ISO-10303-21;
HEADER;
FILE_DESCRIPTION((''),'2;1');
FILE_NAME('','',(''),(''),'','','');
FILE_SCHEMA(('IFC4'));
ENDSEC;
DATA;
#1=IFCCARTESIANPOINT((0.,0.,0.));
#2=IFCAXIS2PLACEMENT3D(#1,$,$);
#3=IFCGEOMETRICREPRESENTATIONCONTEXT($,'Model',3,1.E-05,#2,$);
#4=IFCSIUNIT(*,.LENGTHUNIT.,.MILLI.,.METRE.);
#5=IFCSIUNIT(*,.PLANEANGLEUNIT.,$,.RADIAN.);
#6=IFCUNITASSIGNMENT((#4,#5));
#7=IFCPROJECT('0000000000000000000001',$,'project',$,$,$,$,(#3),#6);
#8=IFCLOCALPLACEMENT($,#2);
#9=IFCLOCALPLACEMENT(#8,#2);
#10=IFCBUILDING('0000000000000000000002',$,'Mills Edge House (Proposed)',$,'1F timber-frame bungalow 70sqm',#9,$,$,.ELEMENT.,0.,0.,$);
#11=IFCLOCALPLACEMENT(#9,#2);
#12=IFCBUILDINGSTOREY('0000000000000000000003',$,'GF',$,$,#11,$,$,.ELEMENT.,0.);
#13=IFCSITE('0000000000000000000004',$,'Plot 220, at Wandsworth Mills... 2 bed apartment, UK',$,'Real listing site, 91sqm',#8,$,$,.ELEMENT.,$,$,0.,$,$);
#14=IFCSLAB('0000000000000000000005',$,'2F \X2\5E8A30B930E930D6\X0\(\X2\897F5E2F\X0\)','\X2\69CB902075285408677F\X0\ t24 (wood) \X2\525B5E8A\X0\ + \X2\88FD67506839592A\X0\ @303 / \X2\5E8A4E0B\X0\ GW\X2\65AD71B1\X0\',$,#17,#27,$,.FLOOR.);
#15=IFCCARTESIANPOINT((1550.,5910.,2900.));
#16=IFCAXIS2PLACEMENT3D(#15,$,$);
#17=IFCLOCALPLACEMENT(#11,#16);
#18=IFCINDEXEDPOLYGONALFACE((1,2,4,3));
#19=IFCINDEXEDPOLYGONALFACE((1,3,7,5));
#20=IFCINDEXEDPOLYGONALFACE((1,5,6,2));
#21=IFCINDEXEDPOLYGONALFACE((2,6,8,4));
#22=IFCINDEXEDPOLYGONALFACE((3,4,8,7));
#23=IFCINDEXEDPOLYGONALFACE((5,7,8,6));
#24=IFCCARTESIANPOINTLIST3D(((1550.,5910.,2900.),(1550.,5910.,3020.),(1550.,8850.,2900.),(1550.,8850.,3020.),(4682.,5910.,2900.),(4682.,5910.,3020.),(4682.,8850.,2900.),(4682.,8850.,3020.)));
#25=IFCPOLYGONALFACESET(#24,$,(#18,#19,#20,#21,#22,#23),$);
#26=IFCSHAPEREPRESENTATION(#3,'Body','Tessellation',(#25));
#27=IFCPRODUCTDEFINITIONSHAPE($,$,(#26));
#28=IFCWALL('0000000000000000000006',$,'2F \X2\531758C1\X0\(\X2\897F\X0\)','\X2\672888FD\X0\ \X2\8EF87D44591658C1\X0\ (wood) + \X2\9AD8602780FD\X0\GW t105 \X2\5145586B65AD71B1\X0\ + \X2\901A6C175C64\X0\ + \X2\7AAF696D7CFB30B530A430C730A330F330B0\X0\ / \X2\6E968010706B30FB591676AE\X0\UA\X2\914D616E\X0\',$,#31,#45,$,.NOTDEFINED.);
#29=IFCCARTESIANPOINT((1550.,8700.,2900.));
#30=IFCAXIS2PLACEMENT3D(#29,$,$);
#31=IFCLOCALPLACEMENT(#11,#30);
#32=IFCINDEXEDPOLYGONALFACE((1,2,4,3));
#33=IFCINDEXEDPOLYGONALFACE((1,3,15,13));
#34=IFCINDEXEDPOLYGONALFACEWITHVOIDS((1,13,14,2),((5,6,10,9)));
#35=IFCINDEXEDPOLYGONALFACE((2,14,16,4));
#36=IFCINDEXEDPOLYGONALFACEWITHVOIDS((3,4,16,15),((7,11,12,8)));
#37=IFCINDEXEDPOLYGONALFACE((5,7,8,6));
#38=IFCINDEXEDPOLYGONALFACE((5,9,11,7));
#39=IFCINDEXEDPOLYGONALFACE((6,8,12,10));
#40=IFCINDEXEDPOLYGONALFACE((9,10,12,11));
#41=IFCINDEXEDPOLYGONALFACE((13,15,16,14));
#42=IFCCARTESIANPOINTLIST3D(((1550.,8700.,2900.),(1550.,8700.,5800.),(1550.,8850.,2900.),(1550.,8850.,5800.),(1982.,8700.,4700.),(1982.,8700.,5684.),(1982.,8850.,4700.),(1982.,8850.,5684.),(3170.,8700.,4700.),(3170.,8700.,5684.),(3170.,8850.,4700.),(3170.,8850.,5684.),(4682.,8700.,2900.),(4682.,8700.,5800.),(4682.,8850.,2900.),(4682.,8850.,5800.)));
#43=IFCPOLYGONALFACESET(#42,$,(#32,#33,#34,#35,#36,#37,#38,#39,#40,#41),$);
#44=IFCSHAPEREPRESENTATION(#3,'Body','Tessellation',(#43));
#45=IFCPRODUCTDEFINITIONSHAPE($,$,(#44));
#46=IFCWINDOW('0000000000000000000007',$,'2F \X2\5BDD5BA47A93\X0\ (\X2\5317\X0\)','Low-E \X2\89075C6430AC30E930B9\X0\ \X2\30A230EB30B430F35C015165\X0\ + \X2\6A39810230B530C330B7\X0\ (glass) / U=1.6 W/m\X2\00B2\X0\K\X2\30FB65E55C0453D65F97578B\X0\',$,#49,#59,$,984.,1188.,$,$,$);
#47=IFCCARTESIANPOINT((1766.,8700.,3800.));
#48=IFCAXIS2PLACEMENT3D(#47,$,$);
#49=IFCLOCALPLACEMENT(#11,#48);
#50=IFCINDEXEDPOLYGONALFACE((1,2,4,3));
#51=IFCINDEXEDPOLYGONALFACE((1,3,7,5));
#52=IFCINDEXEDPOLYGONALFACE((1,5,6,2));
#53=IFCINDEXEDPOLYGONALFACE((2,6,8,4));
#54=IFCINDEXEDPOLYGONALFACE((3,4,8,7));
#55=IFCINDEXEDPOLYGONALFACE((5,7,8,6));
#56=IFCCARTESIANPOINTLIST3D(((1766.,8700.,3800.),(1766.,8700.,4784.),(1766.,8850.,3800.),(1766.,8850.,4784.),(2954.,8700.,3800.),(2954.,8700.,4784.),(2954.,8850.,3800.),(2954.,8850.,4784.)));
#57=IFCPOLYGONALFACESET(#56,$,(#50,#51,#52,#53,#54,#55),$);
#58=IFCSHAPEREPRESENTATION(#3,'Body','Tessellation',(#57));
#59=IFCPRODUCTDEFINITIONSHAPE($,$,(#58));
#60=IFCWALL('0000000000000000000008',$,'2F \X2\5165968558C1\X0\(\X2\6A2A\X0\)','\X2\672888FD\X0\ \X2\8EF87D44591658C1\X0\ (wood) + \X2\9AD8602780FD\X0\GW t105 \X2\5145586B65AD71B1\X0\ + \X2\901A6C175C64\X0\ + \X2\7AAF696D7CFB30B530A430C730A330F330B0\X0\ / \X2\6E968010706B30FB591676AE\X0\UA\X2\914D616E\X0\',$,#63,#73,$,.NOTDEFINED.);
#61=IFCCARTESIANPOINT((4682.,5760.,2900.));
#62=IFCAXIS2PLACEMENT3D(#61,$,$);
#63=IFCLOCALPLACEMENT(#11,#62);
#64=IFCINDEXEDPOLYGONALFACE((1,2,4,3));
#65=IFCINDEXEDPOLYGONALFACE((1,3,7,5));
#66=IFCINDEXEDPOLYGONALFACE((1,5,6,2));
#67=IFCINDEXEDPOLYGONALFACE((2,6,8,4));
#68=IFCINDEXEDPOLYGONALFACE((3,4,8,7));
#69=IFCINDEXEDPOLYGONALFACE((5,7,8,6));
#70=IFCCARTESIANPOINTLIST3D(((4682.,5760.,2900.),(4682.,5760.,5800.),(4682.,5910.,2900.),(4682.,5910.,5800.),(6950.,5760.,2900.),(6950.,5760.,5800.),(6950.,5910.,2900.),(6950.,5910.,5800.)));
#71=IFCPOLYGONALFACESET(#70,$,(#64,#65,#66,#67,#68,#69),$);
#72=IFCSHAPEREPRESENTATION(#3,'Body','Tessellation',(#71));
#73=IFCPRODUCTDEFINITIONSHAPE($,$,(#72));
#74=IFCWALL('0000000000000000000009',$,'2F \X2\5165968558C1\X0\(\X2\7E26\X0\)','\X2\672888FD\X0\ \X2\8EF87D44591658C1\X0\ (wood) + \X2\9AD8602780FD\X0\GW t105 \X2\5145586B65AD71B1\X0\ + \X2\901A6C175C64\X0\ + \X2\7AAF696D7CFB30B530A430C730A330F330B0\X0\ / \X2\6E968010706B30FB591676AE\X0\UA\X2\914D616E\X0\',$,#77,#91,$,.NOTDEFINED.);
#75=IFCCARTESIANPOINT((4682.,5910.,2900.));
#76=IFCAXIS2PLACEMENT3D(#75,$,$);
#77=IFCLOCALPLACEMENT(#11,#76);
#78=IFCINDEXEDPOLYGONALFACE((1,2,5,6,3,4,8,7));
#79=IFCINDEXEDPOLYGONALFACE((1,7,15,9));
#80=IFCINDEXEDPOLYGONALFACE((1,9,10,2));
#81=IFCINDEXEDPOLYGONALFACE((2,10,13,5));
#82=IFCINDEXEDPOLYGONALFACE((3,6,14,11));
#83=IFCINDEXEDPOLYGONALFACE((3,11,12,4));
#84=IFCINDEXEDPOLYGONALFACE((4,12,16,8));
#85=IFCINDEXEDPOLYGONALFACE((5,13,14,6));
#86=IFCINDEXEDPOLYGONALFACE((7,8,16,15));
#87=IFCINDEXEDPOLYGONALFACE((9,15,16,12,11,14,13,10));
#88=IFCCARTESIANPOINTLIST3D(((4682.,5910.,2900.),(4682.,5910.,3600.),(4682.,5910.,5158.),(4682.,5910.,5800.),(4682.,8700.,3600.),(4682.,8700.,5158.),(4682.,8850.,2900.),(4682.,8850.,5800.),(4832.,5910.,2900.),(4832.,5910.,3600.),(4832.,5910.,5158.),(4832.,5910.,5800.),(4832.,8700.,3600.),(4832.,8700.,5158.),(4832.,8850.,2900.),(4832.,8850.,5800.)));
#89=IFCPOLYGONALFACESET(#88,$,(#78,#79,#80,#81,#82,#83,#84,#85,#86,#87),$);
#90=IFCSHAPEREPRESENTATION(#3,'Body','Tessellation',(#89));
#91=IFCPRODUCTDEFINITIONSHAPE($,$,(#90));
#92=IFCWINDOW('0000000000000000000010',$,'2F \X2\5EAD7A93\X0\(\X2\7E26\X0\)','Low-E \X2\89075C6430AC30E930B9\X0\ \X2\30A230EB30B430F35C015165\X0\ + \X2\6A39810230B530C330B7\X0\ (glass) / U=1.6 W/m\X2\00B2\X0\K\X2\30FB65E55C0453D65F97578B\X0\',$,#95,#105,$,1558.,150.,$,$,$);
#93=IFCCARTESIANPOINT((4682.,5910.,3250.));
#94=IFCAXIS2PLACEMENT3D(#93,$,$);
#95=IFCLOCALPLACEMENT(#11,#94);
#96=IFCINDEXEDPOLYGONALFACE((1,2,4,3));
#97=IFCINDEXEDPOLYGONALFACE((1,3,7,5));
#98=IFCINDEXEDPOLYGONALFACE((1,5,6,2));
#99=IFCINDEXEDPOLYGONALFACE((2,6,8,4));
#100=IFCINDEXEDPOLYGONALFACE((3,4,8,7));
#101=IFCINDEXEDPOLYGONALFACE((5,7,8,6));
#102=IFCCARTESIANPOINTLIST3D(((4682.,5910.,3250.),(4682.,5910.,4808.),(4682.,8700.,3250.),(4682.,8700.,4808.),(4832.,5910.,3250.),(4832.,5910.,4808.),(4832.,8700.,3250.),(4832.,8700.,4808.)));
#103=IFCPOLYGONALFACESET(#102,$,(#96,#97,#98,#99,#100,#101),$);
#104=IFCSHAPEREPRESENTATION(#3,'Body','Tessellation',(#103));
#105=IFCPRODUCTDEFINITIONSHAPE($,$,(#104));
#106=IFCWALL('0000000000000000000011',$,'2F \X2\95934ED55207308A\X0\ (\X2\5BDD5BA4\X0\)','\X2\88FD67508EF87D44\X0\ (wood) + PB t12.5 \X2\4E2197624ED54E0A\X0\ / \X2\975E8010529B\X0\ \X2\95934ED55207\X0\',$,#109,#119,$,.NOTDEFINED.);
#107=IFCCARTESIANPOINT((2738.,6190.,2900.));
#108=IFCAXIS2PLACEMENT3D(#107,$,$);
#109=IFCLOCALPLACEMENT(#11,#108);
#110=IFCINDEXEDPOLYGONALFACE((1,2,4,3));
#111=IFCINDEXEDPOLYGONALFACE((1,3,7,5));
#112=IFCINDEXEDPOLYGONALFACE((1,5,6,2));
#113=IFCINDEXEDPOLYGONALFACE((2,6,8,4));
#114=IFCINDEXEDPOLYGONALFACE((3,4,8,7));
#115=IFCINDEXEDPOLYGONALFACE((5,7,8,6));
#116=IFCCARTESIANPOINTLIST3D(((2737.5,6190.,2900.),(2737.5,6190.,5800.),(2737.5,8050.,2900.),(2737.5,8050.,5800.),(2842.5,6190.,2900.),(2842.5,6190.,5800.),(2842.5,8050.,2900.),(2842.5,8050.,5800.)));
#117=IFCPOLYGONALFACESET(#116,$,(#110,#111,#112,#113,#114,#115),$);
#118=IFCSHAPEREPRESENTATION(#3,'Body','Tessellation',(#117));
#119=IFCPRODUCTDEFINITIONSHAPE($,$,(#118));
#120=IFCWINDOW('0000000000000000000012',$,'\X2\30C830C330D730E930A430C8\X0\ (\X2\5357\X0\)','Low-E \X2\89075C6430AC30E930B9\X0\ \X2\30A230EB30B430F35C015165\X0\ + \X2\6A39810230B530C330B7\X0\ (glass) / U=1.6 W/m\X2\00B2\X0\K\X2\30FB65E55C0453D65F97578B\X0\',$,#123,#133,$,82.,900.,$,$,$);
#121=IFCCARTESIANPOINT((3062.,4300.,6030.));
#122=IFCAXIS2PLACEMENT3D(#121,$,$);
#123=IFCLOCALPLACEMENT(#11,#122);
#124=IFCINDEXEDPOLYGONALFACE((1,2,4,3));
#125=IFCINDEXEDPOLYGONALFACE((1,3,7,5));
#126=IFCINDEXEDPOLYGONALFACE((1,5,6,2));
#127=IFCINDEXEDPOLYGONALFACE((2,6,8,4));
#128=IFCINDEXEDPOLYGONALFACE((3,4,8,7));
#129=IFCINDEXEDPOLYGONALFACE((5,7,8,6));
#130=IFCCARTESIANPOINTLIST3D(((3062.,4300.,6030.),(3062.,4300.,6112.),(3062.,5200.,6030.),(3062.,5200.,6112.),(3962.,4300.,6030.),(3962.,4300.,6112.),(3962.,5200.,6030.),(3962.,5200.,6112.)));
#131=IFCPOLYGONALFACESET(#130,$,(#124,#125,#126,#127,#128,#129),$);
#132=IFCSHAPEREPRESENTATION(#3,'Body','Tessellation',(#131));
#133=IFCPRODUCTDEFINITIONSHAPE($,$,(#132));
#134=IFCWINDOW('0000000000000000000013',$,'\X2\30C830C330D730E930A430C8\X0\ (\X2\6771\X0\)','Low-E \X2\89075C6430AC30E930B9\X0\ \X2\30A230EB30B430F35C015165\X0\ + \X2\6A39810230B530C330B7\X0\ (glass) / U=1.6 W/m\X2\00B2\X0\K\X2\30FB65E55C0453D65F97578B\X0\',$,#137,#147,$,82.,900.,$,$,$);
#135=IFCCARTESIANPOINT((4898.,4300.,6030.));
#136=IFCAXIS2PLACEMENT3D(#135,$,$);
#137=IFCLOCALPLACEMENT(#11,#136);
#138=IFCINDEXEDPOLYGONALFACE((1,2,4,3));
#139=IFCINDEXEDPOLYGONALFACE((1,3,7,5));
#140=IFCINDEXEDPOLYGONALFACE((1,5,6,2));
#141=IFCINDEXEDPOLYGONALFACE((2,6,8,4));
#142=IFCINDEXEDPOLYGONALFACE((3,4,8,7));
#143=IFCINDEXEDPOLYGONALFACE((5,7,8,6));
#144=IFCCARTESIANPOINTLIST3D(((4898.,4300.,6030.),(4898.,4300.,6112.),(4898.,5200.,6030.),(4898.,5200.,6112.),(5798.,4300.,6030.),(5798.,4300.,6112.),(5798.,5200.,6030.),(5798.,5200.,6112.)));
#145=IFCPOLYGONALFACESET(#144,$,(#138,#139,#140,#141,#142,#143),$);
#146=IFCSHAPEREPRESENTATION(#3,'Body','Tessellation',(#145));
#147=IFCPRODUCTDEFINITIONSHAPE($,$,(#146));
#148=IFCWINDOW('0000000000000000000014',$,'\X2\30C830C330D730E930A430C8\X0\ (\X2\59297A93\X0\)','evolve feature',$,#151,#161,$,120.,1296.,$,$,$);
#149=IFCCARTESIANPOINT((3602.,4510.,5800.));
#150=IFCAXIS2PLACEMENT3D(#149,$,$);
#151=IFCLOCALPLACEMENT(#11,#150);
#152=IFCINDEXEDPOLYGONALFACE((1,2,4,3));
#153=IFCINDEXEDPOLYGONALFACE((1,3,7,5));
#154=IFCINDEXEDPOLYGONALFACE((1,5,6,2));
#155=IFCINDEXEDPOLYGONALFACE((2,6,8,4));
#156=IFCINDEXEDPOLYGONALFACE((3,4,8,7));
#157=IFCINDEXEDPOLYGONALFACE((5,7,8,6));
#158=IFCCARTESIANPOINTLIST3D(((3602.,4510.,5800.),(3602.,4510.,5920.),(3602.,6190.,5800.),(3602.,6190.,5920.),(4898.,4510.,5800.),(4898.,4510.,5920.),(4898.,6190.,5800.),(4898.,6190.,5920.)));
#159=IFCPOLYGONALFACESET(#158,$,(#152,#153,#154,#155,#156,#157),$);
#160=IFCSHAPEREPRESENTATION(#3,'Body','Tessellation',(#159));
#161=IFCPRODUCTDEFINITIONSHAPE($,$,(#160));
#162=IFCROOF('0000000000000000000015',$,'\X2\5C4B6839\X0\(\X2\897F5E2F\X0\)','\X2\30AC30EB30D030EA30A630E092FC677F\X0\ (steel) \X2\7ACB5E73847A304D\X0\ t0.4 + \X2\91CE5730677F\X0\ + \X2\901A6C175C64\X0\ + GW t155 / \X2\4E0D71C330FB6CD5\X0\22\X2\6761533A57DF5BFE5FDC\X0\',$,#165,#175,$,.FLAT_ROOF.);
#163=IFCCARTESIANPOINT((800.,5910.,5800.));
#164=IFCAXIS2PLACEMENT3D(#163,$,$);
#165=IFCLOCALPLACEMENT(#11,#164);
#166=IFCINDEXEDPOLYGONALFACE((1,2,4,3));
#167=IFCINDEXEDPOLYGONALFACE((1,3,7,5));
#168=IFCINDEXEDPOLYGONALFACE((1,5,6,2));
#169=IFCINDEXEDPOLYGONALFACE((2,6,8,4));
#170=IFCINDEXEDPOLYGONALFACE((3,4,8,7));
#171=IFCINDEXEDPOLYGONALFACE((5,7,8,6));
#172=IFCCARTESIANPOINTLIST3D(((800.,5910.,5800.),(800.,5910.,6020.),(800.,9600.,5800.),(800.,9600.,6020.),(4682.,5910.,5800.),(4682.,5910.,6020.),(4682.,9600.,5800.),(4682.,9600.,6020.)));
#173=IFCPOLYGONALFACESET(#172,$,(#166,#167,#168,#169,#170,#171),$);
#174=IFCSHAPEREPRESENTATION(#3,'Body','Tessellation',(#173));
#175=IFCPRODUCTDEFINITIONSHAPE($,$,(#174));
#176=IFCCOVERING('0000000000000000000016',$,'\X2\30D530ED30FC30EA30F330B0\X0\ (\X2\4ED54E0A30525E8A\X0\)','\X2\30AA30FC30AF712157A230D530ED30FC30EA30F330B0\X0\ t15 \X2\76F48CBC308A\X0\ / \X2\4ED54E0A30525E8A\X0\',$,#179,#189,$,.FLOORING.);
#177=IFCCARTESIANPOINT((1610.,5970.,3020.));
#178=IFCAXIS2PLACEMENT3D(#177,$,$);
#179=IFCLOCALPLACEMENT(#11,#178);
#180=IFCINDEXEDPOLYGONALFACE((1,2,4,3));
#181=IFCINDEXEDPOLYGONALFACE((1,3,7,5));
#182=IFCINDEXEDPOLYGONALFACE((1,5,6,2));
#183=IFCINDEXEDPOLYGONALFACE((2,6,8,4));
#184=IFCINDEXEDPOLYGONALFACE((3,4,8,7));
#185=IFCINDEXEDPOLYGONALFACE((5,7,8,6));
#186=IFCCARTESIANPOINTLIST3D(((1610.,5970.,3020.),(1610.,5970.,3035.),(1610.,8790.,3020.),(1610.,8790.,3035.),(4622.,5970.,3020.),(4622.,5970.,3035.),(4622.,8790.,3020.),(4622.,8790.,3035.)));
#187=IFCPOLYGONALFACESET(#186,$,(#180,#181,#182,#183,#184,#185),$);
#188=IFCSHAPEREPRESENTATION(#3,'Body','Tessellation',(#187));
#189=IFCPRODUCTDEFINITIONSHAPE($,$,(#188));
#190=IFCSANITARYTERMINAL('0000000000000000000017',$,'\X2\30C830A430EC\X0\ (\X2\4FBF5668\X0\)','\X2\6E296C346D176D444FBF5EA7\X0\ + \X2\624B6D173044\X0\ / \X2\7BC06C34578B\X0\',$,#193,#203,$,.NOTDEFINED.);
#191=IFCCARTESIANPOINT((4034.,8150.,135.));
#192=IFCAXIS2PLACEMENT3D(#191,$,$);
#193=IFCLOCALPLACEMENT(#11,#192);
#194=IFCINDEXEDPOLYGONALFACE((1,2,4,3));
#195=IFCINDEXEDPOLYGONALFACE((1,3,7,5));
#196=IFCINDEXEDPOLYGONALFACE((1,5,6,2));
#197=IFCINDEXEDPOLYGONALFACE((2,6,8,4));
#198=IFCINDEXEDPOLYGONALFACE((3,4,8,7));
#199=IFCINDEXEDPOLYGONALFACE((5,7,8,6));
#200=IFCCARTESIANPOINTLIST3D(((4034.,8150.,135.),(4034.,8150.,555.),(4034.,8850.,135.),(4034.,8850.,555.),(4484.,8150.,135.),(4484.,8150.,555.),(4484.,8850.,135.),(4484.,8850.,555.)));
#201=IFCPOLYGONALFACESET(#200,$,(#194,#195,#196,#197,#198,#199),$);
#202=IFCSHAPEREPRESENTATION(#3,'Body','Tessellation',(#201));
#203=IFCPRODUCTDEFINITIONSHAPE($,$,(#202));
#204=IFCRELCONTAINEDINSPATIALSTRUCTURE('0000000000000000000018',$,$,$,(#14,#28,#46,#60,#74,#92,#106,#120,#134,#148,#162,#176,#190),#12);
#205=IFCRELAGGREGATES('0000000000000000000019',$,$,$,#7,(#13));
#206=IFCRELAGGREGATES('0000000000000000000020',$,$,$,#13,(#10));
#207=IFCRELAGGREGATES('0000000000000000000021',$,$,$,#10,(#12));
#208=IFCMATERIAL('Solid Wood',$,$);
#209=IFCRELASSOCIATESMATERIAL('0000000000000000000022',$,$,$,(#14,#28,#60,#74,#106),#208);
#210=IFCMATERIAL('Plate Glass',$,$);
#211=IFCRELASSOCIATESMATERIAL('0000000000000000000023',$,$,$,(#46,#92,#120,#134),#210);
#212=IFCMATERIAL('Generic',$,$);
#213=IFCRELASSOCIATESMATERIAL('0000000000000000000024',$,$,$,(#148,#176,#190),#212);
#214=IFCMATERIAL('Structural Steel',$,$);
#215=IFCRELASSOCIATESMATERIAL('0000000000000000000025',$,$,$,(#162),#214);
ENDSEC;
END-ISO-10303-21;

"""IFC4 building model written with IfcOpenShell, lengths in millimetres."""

from ifc_helpers import new_model, si_unit, frame, frame_2d, origin, place, context, project, spatial, rectangle, extrude, material, element, fill, save


model = new_model("IFC4")

# Units and contexts
model_context = context("Model", 3, precision=1e-05, world=origin())
ifc_project = project(units=[si_unit("LENGTHUNIT", "METRE", prefix="MILLI"), si_unit("PLANEANGLEUNIT", "RADIAN")], contexts=[model_context])

# Site, building, storey
site_placement = place(None, origin())
site = spatial("IfcSite", under=ifc_project, at=site_placement, Name="Plot 220, at Wandsworth Mills... 2 bed apartment, UK", ObjectType="Real listing site, 91sqm", CompositionType="ELEMENT", RefElevation=0.0)
building_placement = place(site_placement, origin())
building = spatial("IfcBuilding", under=site, at=building_placement, Name="Mills Edge House (Proposed)", ObjectType="1F timber-frame bungalow 70sqm", CompositionType="ELEMENT", ElevationOfRefHeight=0.0, ElevationOfTerrain=0.0)
storey_placement = place(building_placement, origin())
storey = spatial("IfcBuildingStorey", under=building, at=storey_placement, Name="GF", CompositionType="ELEMENT", Elevation=0.0)

# Slab
ifc_material_1 = material(Name="Solid Wood")
slab_placement = place(storey_placement, frame((1550.0, 5910.0, 2900.0)))
element("IfcSlab", 1, at=slab_placement, inside=storey, material=ifc_material_1, Name="2F 床スラブ(西帯)", Description="構造用合板 t24 (wood) 剛床 + 製材根太 @303 / 床下 GW断熱", PredefinedType="FLOOR", context=model_context, shape_type="SweptSolid", body=[
    extrude(rectangle(XDim=3132.0, YDim=2940.0, at=frame_2d((1566.0, 1470.0))), frame((1550.0, 5910.0, 2900.0)), (0.0, 0.0, 1.0), 120.0),
])

# Wall, opening, window
wall_1_placement = place(storey_placement, frame((1550.0, 8700.0, 2900.0)))
wall_1 = element("IfcWall", 2, at=wall_1_placement, inside=storey, material=ifc_material_1, Name="2F 北壁(西)", Description="木製 軸組外壁 (wood) + 高性能GW t105 充填断熱 + 通気層 + 窯業系サイディング / 準耐火・外皮UA配慮", PredefinedType="NOTDEFINED", context=model_context, shape_type="SweptSolid", body=[
    extrude(rectangle(XDim=3132.0, YDim=150.0, at=frame_2d((1566.0, 75.0))), frame((1550.0, 8700.0, 2900.0)), (0.0, 0.0, 1.0), 2900.0),
])
opening_1_placement = place(storey_placement, frame((1766.0, 8700.0, 3800.0)))
opening_1 = element("IfcOpeningElement", 3, at=opening_1_placement, cuts=wall_1, PredefinedType="NOTDEFINED", context=model_context, shape_type="SweptSolid", body=[
    extrude(rectangle(XDim=1188.0, YDim=150.0, at=frame_2d((594.0, 75.0))), frame((1766.0, 8700.0, 3800.0)), (0.0, 0.0, 1.0), 984.0),
])
ifc_material_2 = material(Name="Plate Glass")
window_1_placement = place(storey_placement, frame((1766.0, 8700.0, 3800.0)))
window_1 = element("IfcWindow", 4, at=window_1_placement, inside=storey, material=ifc_material_2, Name="2F 寝室窓 (北)", Description="Low-E 複層ガラス アルゴン封入 + 樹脂サッシ (glass) / U=1.6 W/m²K・日射取得型", OverallHeight=984.0, OverallWidth=1188.0, context=model_context, shape_type="SweptSolid", body=[
    extrude(rectangle(XDim=1188.0, YDim=150.0, at=frame_2d((594.0, 75.0))), frame((1766.0, 8700.0, 3800.0)), (0.0, 0.0, 1.0), 984.0),
])
fill(opening_1, window_1)

# Wall
wall_2_placement = place(storey_placement, frame((4682.0, 5760.0, 2900.0)))
element("IfcWall", 5, at=wall_2_placement, inside=storey, material=ifc_material_1, Name="2F 入隅壁(横)", Description="木製 軸組外壁 (wood) + 高性能GW t105 充填断熱 + 通気層 + 窯業系サイディング / 準耐火・外皮UA配慮", PredefinedType="NOTDEFINED", context=model_context, shape_type="SweptSolid", body=[
    extrude(rectangle(XDim=2268.0, YDim=150.0, at=frame_2d((1134.0, 75.0))), frame((4682.0, 5760.0, 2900.0)), (0.0, 0.0, 1.0), 2900.0),
])

# Wall, opening, window
wall_3_placement = place(storey_placement, frame((4682.0, 5910.0, 2900.0)))
wall_3 = element("IfcWall", 6, at=wall_3_placement, inside=storey, material=ifc_material_1, Name="2F 入隅壁(縦)", Description="木製 軸組外壁 (wood) + 高性能GW t105 充填断熱 + 通気層 + 窯業系サイディング / 準耐火・外皮UA配慮", PredefinedType="NOTDEFINED", context=model_context, shape_type="SweptSolid", body=[
    extrude(rectangle(XDim=150.0, YDim=2940.0, at=frame_2d((75.0, 1470.0))), frame((4682.0, 5910.0, 2900.0)), (0.0, 0.0, 1.0), 2900.0),
])
opening_2_placement = place(storey_placement, frame((4682.0, 5910.0, 3250.0)))
opening_2 = element("IfcOpeningElement", 7, at=opening_2_placement, cuts=wall_3, PredefinedType="NOTDEFINED", context=model_context, shape_type="SweptSolid", body=[
    extrude(rectangle(XDim=150.0, YDim=2790.0, at=frame_2d((75.0, 1395.0))), frame((4682.0, 5910.0, 3250.0)), (0.0, 0.0, 1.0), 1558.0),
])
window_2_placement = place(storey_placement, frame((4682.0, 5910.0, 3250.0)))
window_2 = element("IfcWindow", 8, at=window_2_placement, inside=storey, material=ifc_material_2, Name="2F 庭窓(縦)", Description="Low-E 複層ガラス アルゴン封入 + 樹脂サッシ (glass) / U=1.6 W/m²K・日射取得型", OverallHeight=1558.0, OverallWidth=150.0, context=model_context, shape_type="SweptSolid", body=[
    extrude(rectangle(XDim=150.0, YDim=2790.0, at=frame_2d((75.0, 1395.0))), frame((4682.0, 5910.0, 3250.0)), (0.0, 0.0, 1.0), 1558.0),
])
fill(opening_2, window_2)

# Wall
wall_4_placement = place(storey_placement, frame((2738.0, 6190.0, 2900.0)))
element("IfcWall", 9, at=wall_4_placement, inside=storey, material=ifc_material_1, Name="2F 間仕切り (寝室)", Description="製材軸組 (wood) + PB t12.5 両面仕上 / 非耐力 間仕切", PredefinedType="NOTDEFINED", context=model_context, shape_type="SweptSolid", body=[
    extrude(rectangle(XDim=105.0, YDim=1860.0, at=frame_2d((52.0, 930.0))), frame((2738.0, 6190.0, 2900.0)), (0.0, 0.0, 1.0), 2900.0),
])

# Windows
window_3_placement = place(storey_placement, frame((3062.0, 4300.0, 6030.0)))
element("IfcWindow", 10, at=window_3_placement, inside=storey, material=ifc_material_2, Name="トップライト (南)", Description="Low-E 複層ガラス アルゴン封入 + 樹脂サッシ (glass) / U=1.6 W/m²K・日射取得型", OverallHeight=82.0, OverallWidth=900.0, context=model_context, shape_type="SweptSolid", body=[
    extrude(rectangle(XDim=900.0, YDim=900.0, at=frame_2d((450.0, 450.0))), frame((3062.0, 4300.0, 6030.0)), (0.0, 0.0, 1.0), 82.0),
])
window_4_placement = place(storey_placement, frame((4898.0, 4300.0, 6030.0)))
element("IfcWindow", 11, at=window_4_placement, inside=storey, material=ifc_material_2, Name="トップライト (東)", Description="Low-E 複層ガラス アルゴン封入 + 樹脂サッシ (glass) / U=1.6 W/m²K・日射取得型", OverallHeight=82.0, OverallWidth=900.0, context=model_context, shape_type="SweptSolid", body=[
    extrude(rectangle(XDim=900.0, YDim=900.0, at=frame_2d((450.0, 450.0))), frame((4898.0, 4300.0, 6030.0)), (0.0, 0.0, 1.0), 82.0),
])
ifc_material_3 = material(Name="Generic")
window_5_placement = place(storey_placement, frame((3602.0, 4510.0, 5800.0)))
element("IfcWindow", 12, at=window_5_placement, inside=storey, material=ifc_material_3, Name="トップライト (天窓)", Description="evolve feature", OverallHeight=120.0, OverallWidth=1296.0, context=model_context, shape_type="SweptSolid", body=[
    extrude(rectangle(XDim=1296.0, YDim=1680.0, at=frame_2d((648.0, 840.0))), frame((3602.0, 4510.0, 5800.0)), (0.0, 0.0, 1.0), 120.0),
])

# Roof
ifc_material_4 = material(Name="Structural Steel")
for number, where, name in (
    (13, (800.0, 5910.0, 5800.0), "屋根(西帯)"),
):
    element("IfcRoof", number, at=place(storey_placement, frame(where)), inside=storey, material=ifc_material_4, Name=name, Description="ガルバリウム鋼板 (steel) 立平葺き t0.4 + 野地板 + 通気層 + GW t155 / 不燃・法22条区域対応", PredefinedType="FLAT_ROOF", context=model_context, shape_type="SweptSolid", body=[
        extrude(rectangle(XDim=3882.0, YDim=3690.0, at=frame_2d((1941.0, 1845.0))), frame((800.0, 5910.0, 5800.0)), (0.0, 0.0, 1.0), 220.0),
    ])

# Covering
covering_placement = place(storey_placement, frame((1610.0, 5970.0, 3020.0)))
element("IfcCovering", 14, at=covering_placement, inside=storey, material=ifc_material_3, Name="フローリング (仕上げ床)", Description="オーク無垢フローリング t15 直貼り / 仕上げ床", PredefinedType="FLOORING", context=model_context, shape_type="SweptSolid", body=[
    extrude(rectangle(XDim=3012.0, YDim=2820.0, at=frame_2d((1506.0, 1410.0))), frame((1610.0, 5970.0, 3020.0)), (0.0, 0.0, 1.0), 15.0),
])

# Sanitary terminal
sanitary_terminal_placement = place(storey_placement, frame((4034.0, 8150.0, 135.0)))
element("IfcSanitaryTerminal", 15, at=sanitary_terminal_placement, inside=storey, material=ifc_material_3, Name="トイレ (便器)", Description="温水洗浄便座 + 手洗い / 節水型", PredefinedType="NOTDEFINED", context=model_context, shape_type="SweptSolid", body=[
    extrude(rectangle(XDim=450.0, YDim=700.0, at=frame_2d((225.0, 350.0))), frame((4034.0, 8150.0, 135.0)), (0.0, 0.0, 1.0), 420.0),
])

save(model, "model.ifc")
